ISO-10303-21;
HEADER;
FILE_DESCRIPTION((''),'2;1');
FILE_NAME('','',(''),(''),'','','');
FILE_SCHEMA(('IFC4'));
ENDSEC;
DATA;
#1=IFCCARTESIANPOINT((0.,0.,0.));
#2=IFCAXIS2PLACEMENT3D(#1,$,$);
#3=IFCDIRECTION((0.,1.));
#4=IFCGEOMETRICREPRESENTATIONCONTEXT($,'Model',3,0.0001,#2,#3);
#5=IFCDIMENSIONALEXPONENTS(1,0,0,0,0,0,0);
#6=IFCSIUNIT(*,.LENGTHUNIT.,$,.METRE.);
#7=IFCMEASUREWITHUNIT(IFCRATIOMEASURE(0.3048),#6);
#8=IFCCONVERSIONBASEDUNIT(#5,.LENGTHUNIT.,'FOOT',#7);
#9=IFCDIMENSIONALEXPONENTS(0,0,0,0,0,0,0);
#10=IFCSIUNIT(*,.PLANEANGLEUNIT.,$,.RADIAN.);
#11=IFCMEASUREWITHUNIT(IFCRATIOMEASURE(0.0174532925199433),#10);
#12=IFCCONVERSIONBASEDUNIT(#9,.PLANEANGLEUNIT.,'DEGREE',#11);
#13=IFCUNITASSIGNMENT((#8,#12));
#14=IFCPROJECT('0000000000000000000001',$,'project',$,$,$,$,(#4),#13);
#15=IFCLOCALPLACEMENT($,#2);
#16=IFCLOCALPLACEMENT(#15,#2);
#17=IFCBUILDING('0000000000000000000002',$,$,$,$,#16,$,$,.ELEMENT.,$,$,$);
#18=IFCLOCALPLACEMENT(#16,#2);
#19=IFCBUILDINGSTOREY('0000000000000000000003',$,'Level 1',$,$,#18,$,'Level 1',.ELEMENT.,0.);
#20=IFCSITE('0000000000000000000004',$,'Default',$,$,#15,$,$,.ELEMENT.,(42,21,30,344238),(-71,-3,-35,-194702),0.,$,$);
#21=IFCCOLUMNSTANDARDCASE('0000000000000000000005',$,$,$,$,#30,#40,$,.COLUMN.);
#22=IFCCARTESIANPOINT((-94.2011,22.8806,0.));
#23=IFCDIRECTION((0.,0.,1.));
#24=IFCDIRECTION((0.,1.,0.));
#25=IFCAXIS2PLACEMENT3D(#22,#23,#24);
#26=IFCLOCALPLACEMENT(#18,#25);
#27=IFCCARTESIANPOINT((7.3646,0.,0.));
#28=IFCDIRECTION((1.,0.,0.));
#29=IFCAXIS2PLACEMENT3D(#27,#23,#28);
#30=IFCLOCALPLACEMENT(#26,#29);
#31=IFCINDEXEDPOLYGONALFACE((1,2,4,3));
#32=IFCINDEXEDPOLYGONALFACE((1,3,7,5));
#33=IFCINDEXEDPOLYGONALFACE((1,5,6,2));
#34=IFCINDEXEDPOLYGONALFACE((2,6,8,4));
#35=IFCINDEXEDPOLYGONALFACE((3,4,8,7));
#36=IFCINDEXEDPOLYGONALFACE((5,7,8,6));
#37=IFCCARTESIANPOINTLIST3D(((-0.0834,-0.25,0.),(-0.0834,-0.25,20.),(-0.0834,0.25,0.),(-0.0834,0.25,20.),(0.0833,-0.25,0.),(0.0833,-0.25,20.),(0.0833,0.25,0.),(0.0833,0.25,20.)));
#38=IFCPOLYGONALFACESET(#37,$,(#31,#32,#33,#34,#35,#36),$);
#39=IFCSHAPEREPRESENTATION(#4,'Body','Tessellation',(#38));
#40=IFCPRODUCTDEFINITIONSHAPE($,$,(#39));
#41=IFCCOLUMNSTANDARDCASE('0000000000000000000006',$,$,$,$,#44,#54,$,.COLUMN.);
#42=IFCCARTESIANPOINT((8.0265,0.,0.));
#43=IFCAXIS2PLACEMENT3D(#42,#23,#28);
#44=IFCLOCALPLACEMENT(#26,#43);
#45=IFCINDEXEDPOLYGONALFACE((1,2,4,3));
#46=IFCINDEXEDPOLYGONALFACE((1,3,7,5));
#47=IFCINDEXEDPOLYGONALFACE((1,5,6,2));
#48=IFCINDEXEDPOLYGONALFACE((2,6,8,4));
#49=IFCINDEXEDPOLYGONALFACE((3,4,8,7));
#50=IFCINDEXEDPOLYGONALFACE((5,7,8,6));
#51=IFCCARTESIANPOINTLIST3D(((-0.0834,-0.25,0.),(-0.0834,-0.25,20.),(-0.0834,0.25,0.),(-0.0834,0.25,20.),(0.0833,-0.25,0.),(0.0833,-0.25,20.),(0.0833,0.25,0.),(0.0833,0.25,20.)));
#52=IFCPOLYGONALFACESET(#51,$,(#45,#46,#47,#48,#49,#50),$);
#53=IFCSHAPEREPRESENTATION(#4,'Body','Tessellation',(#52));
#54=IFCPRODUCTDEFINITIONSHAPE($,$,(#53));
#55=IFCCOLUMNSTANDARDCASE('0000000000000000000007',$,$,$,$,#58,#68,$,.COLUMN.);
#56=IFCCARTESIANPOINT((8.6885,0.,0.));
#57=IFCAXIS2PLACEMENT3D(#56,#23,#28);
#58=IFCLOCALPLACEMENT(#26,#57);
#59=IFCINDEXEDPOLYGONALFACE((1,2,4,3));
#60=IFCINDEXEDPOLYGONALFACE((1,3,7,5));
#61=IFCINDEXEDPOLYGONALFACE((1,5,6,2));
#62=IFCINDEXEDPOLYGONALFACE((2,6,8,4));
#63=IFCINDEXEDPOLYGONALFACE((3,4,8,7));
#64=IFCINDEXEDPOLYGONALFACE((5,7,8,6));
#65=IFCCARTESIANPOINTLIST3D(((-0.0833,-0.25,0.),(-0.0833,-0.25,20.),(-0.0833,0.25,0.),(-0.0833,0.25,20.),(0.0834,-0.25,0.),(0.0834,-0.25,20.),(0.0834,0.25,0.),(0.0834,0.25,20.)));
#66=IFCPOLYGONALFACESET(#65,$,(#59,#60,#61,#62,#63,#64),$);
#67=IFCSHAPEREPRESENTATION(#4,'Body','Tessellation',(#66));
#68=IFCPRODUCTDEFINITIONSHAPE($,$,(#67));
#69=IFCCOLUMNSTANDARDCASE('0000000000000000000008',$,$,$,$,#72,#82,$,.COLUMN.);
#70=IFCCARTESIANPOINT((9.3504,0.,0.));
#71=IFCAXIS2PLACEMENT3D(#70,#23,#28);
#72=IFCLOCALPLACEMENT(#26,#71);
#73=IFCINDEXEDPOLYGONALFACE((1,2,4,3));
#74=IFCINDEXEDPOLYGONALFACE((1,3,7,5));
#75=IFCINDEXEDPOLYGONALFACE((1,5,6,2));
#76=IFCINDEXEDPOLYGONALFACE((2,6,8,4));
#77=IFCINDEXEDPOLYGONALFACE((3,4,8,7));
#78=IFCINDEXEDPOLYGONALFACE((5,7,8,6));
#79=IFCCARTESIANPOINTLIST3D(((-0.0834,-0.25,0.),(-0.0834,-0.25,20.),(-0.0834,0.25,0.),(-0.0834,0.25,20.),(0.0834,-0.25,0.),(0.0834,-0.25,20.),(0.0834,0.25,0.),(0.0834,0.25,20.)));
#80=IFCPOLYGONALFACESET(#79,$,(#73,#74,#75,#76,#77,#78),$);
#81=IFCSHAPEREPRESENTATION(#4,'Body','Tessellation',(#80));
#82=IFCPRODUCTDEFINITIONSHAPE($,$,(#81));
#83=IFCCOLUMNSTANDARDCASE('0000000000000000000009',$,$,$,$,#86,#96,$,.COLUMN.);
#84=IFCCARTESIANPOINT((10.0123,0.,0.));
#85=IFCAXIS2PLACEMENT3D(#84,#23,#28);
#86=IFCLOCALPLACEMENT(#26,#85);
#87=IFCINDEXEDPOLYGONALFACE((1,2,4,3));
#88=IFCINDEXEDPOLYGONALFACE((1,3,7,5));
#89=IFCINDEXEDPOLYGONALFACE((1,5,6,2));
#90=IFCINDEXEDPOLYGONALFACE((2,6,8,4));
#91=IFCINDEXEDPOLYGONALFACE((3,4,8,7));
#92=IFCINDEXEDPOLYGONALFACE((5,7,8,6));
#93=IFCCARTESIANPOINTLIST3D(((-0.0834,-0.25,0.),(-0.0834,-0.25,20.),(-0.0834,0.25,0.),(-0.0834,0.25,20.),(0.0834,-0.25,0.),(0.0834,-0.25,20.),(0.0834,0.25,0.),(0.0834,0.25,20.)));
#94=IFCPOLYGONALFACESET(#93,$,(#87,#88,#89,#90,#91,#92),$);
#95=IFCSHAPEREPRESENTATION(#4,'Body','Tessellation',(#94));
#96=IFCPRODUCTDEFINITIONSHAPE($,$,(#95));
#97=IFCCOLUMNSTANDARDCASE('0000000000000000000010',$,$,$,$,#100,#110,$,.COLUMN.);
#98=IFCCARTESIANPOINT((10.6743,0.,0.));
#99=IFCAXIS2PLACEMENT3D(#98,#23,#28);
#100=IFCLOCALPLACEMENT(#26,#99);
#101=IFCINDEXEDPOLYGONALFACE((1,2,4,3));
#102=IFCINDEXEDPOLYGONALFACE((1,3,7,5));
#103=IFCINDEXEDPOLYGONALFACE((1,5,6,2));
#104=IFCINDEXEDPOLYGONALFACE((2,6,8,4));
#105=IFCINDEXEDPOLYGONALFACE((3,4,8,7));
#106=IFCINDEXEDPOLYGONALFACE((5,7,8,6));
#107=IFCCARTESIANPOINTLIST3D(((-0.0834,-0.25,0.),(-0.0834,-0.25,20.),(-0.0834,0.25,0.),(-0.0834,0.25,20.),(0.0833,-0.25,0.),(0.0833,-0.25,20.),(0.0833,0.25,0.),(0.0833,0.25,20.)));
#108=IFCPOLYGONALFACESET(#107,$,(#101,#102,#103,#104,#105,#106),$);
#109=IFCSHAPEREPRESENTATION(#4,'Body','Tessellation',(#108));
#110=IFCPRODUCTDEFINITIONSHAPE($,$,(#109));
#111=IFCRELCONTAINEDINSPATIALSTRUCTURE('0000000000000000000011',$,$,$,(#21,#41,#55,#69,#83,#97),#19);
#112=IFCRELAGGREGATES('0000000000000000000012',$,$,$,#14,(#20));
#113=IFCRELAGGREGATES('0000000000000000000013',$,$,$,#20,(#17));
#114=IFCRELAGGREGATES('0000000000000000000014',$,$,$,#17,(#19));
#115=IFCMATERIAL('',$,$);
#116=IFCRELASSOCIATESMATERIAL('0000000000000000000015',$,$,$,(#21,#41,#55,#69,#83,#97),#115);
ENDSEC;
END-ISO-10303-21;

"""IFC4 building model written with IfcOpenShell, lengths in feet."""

from ifc_helpers import new_model, entity, si_unit, converted_unit, direction, frame, origin, place, context, project, spatial, rectangle, extrude, material, element, save


model = new_model("IFC4")

# Units and contexts
model_context = context("Model", 3, precision=0.0001, world=origin(), true_north=direction((0.0, 1.0)))
ifc_project = project(units=[converted_unit("LENGTHUNIT", "FOOT", entity("IfcRatioMeasure", 0.3048), si_unit("LENGTHUNIT", "METRE"), dimensions=[1, 0, 0, 0, 0, 0, 0]), converted_unit("PLANEANGLEUNIT", "DEGREE", entity("IfcRatioMeasure", 0.0174532925199433), si_unit("PLANEANGLEUNIT", "RADIAN"), dimensions=[0, 0, 0, 0, 0, 0, 0])], contexts=[model_context])

# Site, building, storey
site_placement = place(None, origin())
site = spatial("IfcSite", under=ifc_project, at=site_placement, Name="Default", CompositionType="ELEMENT", RefLatitude=(42, 21, 30, 344238), RefLongitude=(-71, -3, -35, -194702), RefElevation=0.0)
building_placement = place(site_placement, origin())
building = spatial("IfcBuilding", under=site, at=building_placement, CompositionType="ELEMENT")
storey_placement = place(building_placement, origin())
storey = spatial("IfcBuildingStorey", under=building, at=storey_placement, Name="Level 1", LongName="Level 1", CompositionType="ELEMENT", Elevation=0.0)

# Columns
ifc_material_1 = material(Name="")
wall_1_placement = place(storey_placement, frame((-94.2011, 22.8806, 0.0), z_axis=(0.0, 0.0, 1.0), x_axis=(0.0, 1.0, 0.0)))
for number, where, z_axis, x_axis in (
    (1, (7.3646, 0.0, 0.0), (0.0, 0.0, 1.0), (1.0, 0.0, 0.0)),
    (2, (8.0265, 0.0, 0.0), (0.0, 0.0, 1.0), (1.0, 0.0, 0.0)),
    (3, (8.6885, 0.0, 0.0), (0.0, 0.0, 1.0), (1.0, 0.0, 0.0)),
    (4, (9.3504, 0.0, 0.0), (0.0, 0.0, 1.0), (1.0, 0.0, 0.0)),
    (5, (10.0123, 0.0, 0.0), (0.0, 0.0, 1.0), (1.0, 0.0, 0.0)),
    (6, (10.6743, 0.0, 0.0), (0.0, 0.0, 1.0), (1.0, 0.0, 0.0)),
):
    element("IfcColumnStandardCase", number, at=place(wall_1_placement, frame(where, z_axis=z_axis, x_axis=x_axis)), inside=storey, material=ifc_material_1, PredefinedType="COLUMN", context=model_context, shape_type="SweptSolid", body=[
        extrude(rectangle(XDim=0.1667, YDim=0.5), origin(), (0.0, 0.0, 1.0), 20.0),
    ])

save(model, "model.ifc")
